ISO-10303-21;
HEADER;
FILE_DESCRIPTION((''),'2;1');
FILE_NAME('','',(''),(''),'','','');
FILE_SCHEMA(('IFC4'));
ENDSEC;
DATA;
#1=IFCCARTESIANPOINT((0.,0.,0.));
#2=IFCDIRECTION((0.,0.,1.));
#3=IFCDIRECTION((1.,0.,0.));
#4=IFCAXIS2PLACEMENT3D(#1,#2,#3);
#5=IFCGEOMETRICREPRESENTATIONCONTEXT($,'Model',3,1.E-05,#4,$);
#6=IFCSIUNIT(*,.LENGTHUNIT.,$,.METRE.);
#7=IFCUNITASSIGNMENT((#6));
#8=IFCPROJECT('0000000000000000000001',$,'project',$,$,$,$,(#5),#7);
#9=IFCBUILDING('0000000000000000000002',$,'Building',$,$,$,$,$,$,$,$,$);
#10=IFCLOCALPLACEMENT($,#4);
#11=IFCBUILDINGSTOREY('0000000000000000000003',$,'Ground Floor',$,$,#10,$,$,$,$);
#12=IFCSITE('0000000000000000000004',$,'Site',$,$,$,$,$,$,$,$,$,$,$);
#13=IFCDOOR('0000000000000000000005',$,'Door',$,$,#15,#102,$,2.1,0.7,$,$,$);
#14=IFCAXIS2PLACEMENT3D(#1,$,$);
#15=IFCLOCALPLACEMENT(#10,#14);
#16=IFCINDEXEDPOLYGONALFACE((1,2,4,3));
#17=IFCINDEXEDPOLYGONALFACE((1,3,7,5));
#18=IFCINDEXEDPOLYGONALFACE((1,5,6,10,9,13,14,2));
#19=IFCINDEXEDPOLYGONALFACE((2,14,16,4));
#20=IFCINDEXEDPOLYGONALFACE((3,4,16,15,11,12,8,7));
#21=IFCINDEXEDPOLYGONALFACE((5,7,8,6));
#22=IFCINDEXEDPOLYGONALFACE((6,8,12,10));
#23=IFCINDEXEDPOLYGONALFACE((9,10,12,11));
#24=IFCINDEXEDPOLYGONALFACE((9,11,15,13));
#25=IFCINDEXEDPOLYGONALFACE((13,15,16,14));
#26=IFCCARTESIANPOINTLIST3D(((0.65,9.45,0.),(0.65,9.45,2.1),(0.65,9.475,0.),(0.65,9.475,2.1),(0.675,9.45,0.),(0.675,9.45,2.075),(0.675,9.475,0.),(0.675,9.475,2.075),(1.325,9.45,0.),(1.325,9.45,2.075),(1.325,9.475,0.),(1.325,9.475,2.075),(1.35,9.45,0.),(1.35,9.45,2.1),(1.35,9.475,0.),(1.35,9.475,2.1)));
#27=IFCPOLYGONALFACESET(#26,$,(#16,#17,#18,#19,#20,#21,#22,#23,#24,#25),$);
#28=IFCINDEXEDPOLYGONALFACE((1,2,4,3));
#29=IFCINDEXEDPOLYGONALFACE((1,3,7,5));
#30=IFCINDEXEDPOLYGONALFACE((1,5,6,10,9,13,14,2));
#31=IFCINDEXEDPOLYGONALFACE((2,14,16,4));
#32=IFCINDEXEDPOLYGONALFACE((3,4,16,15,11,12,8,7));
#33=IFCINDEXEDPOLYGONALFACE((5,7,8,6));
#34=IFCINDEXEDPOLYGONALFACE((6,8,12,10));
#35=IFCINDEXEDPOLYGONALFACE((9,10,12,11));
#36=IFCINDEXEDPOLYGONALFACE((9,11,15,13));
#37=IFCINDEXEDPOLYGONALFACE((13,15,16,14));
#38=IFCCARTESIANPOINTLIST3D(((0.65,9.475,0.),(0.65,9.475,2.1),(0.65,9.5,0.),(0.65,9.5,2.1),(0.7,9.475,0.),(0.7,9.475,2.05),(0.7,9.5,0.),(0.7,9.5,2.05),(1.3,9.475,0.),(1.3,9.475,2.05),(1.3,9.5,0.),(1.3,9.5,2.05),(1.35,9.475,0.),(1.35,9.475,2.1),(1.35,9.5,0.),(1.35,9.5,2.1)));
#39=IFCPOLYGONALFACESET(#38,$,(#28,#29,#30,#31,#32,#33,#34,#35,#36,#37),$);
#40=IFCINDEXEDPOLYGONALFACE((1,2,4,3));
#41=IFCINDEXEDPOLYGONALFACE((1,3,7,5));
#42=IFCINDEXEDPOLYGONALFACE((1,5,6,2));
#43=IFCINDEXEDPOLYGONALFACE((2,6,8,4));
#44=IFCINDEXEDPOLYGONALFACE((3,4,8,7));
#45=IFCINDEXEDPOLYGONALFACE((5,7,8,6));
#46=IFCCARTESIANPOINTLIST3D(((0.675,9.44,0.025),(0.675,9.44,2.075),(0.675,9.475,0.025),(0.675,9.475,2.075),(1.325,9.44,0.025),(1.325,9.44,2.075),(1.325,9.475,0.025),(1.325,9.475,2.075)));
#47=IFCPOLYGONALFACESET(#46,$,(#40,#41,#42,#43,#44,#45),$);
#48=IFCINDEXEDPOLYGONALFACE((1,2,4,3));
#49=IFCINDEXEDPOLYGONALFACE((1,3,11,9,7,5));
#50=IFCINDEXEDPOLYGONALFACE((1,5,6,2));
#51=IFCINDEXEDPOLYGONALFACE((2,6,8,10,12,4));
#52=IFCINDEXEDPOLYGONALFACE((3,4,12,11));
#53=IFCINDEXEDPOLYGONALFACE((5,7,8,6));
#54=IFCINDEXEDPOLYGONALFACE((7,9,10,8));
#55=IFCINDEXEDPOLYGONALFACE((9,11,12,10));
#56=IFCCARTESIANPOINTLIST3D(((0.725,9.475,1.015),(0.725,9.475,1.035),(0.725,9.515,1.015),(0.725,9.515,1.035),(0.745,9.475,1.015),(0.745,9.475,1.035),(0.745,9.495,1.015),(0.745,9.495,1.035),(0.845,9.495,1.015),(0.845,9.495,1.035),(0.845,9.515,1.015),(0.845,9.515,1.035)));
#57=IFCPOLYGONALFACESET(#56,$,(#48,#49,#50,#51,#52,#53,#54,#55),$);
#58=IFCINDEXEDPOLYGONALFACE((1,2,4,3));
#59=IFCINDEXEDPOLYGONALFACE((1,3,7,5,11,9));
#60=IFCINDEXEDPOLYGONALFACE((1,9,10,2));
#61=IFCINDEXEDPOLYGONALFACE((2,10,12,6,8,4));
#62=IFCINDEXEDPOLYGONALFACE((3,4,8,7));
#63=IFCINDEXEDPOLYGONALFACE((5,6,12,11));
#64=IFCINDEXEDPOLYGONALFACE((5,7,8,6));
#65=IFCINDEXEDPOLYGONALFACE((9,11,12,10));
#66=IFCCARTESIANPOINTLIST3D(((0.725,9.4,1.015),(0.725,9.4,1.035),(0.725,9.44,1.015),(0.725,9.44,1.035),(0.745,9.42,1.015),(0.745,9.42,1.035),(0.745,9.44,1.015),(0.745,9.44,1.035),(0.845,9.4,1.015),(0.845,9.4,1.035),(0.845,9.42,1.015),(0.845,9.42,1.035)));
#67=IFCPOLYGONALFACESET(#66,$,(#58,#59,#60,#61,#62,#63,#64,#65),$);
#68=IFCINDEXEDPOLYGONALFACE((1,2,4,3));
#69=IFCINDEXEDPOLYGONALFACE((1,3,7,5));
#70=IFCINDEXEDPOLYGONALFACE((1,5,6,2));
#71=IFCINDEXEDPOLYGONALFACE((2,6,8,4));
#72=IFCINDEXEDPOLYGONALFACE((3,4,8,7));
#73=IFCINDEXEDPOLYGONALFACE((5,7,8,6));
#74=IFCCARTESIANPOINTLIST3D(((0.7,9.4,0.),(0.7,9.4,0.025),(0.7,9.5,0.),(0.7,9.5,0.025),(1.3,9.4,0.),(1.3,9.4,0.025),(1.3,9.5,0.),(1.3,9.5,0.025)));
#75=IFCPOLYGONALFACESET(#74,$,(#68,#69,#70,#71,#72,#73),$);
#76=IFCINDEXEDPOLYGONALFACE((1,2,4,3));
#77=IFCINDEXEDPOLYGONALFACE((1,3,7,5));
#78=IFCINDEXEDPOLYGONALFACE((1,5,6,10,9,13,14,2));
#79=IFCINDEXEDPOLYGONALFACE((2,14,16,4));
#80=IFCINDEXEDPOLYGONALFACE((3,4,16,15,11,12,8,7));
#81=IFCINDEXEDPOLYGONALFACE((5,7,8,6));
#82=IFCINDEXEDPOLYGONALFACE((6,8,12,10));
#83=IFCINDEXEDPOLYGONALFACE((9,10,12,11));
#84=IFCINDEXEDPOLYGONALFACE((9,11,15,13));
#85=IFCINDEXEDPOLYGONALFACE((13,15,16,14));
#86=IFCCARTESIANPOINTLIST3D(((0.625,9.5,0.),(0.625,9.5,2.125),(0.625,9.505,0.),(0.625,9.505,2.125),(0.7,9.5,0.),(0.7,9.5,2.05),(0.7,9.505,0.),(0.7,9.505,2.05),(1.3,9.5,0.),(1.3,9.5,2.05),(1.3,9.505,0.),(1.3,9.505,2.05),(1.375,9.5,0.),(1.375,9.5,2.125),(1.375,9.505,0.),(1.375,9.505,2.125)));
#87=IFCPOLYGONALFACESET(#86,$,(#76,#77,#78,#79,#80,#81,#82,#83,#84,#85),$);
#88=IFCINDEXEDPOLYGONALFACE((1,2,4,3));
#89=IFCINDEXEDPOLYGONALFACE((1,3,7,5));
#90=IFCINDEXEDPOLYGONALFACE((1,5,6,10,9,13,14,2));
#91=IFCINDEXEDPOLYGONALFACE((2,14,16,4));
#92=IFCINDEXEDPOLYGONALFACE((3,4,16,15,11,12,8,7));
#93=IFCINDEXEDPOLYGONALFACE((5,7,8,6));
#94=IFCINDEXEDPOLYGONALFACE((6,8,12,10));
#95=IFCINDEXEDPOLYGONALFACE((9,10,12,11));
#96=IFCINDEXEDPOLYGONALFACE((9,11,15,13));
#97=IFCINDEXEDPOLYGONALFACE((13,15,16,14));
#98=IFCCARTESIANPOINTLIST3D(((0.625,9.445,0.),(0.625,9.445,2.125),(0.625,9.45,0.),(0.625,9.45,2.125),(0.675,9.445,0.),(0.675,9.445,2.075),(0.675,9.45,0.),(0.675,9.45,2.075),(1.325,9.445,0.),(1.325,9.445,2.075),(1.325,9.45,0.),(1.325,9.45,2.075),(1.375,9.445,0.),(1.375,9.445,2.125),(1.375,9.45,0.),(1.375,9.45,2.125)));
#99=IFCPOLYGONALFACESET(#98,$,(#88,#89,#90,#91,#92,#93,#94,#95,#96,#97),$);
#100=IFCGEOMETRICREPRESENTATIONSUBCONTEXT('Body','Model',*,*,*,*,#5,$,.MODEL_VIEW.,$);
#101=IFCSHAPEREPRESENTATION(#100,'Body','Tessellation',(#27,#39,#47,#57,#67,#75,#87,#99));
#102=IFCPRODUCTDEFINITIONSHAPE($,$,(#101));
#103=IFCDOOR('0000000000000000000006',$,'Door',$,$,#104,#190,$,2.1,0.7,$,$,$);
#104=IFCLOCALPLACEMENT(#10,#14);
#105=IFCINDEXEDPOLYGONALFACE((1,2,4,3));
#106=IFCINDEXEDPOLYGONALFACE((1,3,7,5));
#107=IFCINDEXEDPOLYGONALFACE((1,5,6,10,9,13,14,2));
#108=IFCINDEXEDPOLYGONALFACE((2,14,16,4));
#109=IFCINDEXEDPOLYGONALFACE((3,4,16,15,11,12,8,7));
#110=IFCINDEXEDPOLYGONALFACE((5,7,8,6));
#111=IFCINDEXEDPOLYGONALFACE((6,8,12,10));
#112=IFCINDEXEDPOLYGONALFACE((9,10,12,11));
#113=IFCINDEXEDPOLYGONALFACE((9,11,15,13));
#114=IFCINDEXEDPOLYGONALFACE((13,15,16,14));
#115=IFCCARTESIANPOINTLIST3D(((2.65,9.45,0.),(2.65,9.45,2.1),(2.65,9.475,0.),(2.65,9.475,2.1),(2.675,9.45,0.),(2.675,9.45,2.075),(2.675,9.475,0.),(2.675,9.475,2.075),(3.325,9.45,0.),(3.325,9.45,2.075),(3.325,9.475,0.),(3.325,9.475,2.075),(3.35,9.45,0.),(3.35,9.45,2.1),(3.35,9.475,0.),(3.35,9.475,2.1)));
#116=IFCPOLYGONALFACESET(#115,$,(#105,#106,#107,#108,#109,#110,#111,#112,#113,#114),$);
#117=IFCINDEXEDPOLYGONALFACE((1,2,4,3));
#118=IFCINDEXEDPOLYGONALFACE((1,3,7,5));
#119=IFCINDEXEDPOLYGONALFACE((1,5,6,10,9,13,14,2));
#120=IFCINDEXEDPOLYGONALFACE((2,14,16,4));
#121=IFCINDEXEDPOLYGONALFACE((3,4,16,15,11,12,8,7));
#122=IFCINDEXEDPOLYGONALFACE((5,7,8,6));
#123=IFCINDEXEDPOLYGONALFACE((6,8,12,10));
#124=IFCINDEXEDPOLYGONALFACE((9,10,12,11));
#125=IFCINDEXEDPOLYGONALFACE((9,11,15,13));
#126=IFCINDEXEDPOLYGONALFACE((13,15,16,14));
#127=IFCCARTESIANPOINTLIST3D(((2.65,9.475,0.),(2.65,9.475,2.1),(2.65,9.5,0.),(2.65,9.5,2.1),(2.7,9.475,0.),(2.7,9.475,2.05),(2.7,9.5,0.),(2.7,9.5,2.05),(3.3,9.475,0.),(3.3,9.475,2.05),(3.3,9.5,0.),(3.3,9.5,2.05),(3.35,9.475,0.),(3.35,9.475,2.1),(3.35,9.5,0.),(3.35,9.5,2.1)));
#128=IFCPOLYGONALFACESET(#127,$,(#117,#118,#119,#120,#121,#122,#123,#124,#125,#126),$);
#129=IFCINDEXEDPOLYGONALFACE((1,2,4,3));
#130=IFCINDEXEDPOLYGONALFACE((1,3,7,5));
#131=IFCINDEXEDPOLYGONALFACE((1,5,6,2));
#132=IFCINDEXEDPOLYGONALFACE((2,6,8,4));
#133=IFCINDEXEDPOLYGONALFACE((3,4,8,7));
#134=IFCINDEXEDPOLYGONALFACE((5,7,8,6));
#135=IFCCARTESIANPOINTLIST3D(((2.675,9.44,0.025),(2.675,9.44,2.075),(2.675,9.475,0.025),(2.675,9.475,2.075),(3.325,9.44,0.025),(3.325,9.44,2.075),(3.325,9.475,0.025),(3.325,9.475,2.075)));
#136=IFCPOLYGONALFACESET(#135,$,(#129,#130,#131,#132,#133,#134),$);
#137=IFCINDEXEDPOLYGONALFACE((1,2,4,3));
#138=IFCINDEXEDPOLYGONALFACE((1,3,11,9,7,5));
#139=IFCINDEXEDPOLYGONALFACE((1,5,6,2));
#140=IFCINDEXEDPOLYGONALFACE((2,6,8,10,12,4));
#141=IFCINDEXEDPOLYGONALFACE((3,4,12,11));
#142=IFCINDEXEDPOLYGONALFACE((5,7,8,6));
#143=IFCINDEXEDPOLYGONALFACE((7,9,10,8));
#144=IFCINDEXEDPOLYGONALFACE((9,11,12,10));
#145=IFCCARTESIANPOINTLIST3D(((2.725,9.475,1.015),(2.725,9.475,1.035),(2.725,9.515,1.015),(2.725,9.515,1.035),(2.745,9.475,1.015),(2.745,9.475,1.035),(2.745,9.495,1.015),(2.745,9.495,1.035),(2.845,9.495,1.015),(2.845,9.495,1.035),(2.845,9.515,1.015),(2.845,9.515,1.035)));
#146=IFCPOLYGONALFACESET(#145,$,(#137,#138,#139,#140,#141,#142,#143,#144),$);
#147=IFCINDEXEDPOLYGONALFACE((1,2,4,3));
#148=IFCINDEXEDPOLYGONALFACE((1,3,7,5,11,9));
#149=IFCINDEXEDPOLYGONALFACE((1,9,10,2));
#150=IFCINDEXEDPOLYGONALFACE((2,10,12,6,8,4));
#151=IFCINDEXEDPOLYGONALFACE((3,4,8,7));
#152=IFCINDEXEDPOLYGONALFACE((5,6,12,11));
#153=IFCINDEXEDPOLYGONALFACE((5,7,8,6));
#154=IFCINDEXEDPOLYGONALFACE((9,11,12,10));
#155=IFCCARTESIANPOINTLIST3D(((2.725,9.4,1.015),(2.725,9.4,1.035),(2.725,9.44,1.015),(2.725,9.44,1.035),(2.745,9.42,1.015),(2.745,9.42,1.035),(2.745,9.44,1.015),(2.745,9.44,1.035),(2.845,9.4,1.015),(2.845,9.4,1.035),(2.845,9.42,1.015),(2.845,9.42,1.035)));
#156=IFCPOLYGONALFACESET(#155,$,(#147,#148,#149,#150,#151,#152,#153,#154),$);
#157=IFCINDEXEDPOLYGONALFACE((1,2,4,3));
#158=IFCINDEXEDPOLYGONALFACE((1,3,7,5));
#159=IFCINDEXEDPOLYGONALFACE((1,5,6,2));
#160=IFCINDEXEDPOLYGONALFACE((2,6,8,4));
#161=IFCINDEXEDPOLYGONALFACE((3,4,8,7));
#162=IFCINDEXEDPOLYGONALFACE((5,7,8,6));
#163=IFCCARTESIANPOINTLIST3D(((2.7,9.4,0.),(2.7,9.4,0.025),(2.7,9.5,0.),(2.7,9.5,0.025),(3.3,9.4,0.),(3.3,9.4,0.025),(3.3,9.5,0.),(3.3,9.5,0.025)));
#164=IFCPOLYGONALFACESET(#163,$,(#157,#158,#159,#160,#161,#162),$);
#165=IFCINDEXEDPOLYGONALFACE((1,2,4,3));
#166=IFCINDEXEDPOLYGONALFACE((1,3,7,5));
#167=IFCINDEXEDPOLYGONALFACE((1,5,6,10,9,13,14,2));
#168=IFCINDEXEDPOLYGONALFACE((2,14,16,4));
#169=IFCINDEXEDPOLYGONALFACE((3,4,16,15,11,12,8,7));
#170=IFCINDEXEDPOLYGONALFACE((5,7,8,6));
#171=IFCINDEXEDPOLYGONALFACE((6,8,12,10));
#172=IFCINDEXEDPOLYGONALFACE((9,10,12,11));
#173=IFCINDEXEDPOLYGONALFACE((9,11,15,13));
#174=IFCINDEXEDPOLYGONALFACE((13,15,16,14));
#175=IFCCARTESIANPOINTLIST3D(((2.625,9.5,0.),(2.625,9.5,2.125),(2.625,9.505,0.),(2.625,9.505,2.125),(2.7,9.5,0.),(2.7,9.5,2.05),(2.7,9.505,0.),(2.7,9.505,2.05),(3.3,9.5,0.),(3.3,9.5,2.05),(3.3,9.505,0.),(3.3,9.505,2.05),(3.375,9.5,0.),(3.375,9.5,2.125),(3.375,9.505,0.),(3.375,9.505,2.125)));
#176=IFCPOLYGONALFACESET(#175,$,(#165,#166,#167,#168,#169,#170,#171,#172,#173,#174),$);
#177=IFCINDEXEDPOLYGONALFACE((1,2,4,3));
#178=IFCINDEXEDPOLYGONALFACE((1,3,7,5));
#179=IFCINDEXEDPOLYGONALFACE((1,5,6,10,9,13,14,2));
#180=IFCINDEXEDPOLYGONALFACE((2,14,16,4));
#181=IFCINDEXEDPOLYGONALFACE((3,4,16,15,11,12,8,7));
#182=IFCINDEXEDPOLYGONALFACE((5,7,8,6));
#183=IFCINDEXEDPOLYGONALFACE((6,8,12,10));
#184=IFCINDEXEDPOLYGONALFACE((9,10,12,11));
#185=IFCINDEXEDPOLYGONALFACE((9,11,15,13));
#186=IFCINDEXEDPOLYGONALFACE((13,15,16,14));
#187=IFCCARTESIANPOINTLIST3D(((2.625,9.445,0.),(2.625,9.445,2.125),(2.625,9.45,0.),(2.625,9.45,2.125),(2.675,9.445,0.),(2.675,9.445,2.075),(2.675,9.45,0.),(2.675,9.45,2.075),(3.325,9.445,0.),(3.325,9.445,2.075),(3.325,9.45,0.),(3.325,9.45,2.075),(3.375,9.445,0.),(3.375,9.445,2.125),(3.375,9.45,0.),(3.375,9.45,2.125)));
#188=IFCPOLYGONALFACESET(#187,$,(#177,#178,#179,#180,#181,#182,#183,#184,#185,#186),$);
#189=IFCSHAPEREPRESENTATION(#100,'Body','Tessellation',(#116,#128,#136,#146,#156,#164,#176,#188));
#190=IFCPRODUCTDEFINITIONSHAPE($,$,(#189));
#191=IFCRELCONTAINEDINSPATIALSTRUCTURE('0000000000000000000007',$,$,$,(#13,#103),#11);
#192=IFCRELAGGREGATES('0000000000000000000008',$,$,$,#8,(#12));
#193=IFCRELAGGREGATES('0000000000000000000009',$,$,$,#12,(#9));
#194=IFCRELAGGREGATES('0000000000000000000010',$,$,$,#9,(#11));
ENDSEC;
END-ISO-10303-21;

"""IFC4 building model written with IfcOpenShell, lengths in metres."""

from ifc_helpers import new_model, si_unit, frame, origin_with_axes, place, context, subcontext, project, spatial, line, indexed_curve, outline, extrude, element, save


model = new_model("IFC4")

# Units and contexts
model_context = context("Model", 3, precision=1e-05, world=origin_with_axes())
body_context = subcontext(model_context, "Body", "Model", "MODEL_VIEW")
ifc_project = project(units=[si_unit("LENGTHUNIT", "METRE")], contexts=[model_context])

# Site, building, storey
site = spatial("IfcSite", under=ifc_project, Name="Site")
building = spatial("IfcBuilding", under=site, Name="Building")
storey_placement = place(None, origin_with_axes())
storey = spatial("IfcBuildingStorey", under=building, at=storey_placement, Name="Ground Floor")

# Doors
door_1_placement = place(storey_placement, frame((1.35, 9.5, 0.0), z_axis=(0.0, 0.0, 1.0), x_axis=(-1.0, 0.0, 0.0)))
element("IfcDoor", 1, at=door_1_placement, inside=storey, Name="Door", OverallHeight=2.1, OverallWidth=0.7, context=body_context, shape_type="SweptSolid", body=[
    extrude(outline(indexed_curve([(0.0, 0.0), (0.0, 2.1), (0.7, 2.1), (0.7, 0.0), (0.675, 0.0), (0.675, 2.075), (0.025, 2.075), (0.025, 0.0)], segments=[line(1, 2, 3, 4, 5, 6, 7, 8, 1)])), frame((0.0, 0.025, 0.0), z_axis=(0.0, -1.0, 0.0), x_axis=(1.0, 0.0, 0.0)), (0.0, 0.0, -1.0), 0.025),
    extrude(outline(indexed_curve([(0.0, 0.0), (0.0, 2.1), (0.7, 2.1), (0.7, 0.0), (0.65, 0.0), (0.65, 2.05), (0.05, 2.05), (0.05, 0.0)], segments=[line(1, 2, 3, 4, 5, 6, 7, 8, 1)])), frame((0.0, 0.0, 0.0), z_axis=(0.0, -1.0, 0.0), x_axis=(1.0, 0.0, 0.0)), (0.0, 0.0, -1.0), 0.025),
    extrude(outline(indexed_curve([(0.0, 0.0), (0.65, 0.0), (0.65, 0.035), (0.0, 0.035)], segments=[line(1, 2, 3, 4, 1)])), frame((0.025, 0.025, 0.025), z_axis=(0.0, 0.0, 1.0), x_axis=(1.0, 0.0, 0.0)), (0.0, 0.0, 1.0), 2.05),
    extrude(outline(indexed_curve([(0.0, 0.0), (0.0, -0.04), (-0.12, -0.04), (-0.12, -0.02), (-0.02, -0.02), (-0.02, 0.0)], segments=[line(1, 2, 3, 4, 5, 6, 1)])), frame((0.625, 0.025, 1.015), z_axis=(0.0, 0.0, 1.0), x_axis=(1.0, 0.0, 0.0)), (0.0, 0.0, 1.0), 0.02),
    extrude(outline(indexed_curve([(0.0, 0.0), (0.0, 0.04), (-0.12, 0.04), (-0.12, 0.02), (-0.02, 0.02), (-0.02, 0.0)], segments=[line(1, 2, 3, 4, 5, 6, 1)])), frame((0.625, 0.06, 1.015), z_axis=(0.0, 0.0, 1.0), x_axis=(1.0, 0.0, 0.0)), (0.0, 0.0, 1.0), 0.02),
    extrude(outline(indexed_curve([(0.0, 0.0), (0.6, 0.0), (0.6, 0.1), (0.0, 0.1)], segments=[line(1, 2, 3, 4, 1)])), frame((0.05, 0.0, 0.0), z_axis=(0.0, 0.0, 1.0), x_axis=(1.0, 0.0, 0.0)), (0.0, 0.0, 1.0), 0.025),
    extrude(outline(indexed_curve([(0.0, 0.0), (0.0, 2.125), (0.75, 2.125), (0.75, 0.0), (0.675, 0.0), (0.675, 2.05), (0.075, 2.05), (0.075, 0.0)], segments=[line(1, 2, 3, 4, 5, 6, 7, 8, 1)])), frame((-0.025, -0.005, 0.0), z_axis=(0.0, -1.0, 0.0), x_axis=(1.0, 0.0, 0.0)), (0.0, 0.0, -1.0), 0.005),
    extrude(outline(indexed_curve([(0.0, 0.0), (0.0, 2.125), (0.75, 2.125), (0.75, 0.0), (0.7, 0.0), (0.7, 2.075), (0.05, 2.075), (0.05, 0.0)], segments=[line(1, 2, 3, 4, 5, 6, 7, 8, 1)])), frame((-0.025, 0.05, 0.0), z_axis=(0.0, -1.0, 0.0), x_axis=(1.0, 0.0, 0.0)), (0.0, 0.0, -1.0), 0.005),
])
door_2_placement = place(storey_placement, frame((3.35, 9.5, 0.0), z_axis=(0.0, 0.0, 1.0), x_axis=(-1.0, 0.0, 0.0)))
element("IfcDoor", 2, at=door_2_placement, inside=storey, Name="Door", OverallHeight=2.1, OverallWidth=0.7, context=body_context, shape_type="SweptSolid", body=[
    extrude(outline(indexed_curve([(0.0, 0.0), (0.0, 2.1), (0.7, 2.1), (0.7, 0.0), (0.675, 0.0), (0.675, 2.075), (0.025, 2.075), (0.025, 0.0)], segments=[line(1, 2, 3, 4, 5, 6, 7, 8, 1)])), frame((0.0, 0.025, 0.0), z_axis=(0.0, -1.0, 0.0), x_axis=(1.0, 0.0, 0.0)), (0.0, 0.0, -1.0), 0.025),
    extrude(outline(indexed_curve([(0.0, 0.0), (0.0, 2.1), (0.7, 2.1), (0.7, 0.0), (0.65, 0.0), (0.65, 2.05), (0.05, 2.05), (0.05, 0.0)], segments=[line(1, 2, 3, 4, 5, 6, 7, 8, 1)])), frame((0.0, 0.0, 0.0), z_axis=(0.0, -1.0, 0.0), x_axis=(1.0, 0.0, 0.0)), (0.0, 0.0, -1.0), 0.025),
    extrude(outline(indexed_curve([(0.0, 0.0), (0.65, 0.0), (0.65, 0.035), (0.0, 0.035)], segments=[line(1, 2, 3, 4, 1)])), frame((0.025, 0.025, 0.025), z_axis=(0.0, 0.0, 1.0), x_axis=(1.0, 0.0, 0.0)), (0.0, 0.0, 1.0), 2.05),
    extrude(outline(indexed_curve([(0.0, 0.0), (0.0, -0.04), (-0.12, -0.04), (-0.12, -0.02), (-0.02, -0.02), (-0.02, 0.0)], segments=[line(1, 2, 3, 4, 5, 6, 1)])), frame((0.625, 0.025, 1.015), z_axis=(0.0, 0.0, 1.0), x_axis=(1.0, 0.0, 0.0)), (0.0, 0.0, 1.0), 0.02),
    extrude(outline(indexed_curve([(0.0, 0.0), (0.0, 0.04), (-0.12, 0.04), (-0.12, 0.02), (-0.02, 0.02), (-0.02, 0.0)], segments=[line(1, 2, 3, 4, 5, 6, 1)])), frame((0.625, 0.06, 1.015), z_axis=(0.0, 0.0, 1.0), x_axis=(1.0, 0.0, 0.0)), (0.0, 0.0, 1.0), 0.02),
    extrude(outline(indexed_curve([(0.0, 0.0), (0.6, 0.0), (0.6, 0.1), (0.0, 0.1)], segments=[line(1, 2, 3, 4, 1)])), frame((0.05, 0.0, 0.0), z_axis=(0.0, 0.0, 1.0), x_axis=(1.0, 0.0, 0.0)), (0.0, 0.0, 1.0), 0.025),
    extrude(outline(indexed_curve([(0.0, 0.0), (0.0, 2.125), (0.75, 2.125), (0.75, 0.0), (0.675, 0.0), (0.675, 2.05), (0.075, 2.05), (0.075, 0.0)], segments=[line(1, 2, 3, 4, 5, 6, 7, 8, 1)])), frame((-0.025, -0.005, 0.0), z_axis=(0.0, -1.0, 0.0), x_axis=(1.0, 0.0, 0.0)), (0.0, 0.0, -1.0), 0.005),
    extrude(outline(indexed_curve([(0.0, 0.0), (0.0, 2.125), (0.75, 2.125), (0.75, 0.0), (0.7, 0.0), (0.7, 2.075), (0.05, 2.075), (0.05, 0.0)], segments=[line(1, 2, 3, 4, 5, 6, 7, 8, 1)])), frame((-0.025, 0.05, 0.0), z_axis=(0.0, -1.0, 0.0), x_axis=(1.0, 0.0, 0.0)), (0.0, 0.0, -1.0), 0.005),
])

save(model, "model.ifc")
